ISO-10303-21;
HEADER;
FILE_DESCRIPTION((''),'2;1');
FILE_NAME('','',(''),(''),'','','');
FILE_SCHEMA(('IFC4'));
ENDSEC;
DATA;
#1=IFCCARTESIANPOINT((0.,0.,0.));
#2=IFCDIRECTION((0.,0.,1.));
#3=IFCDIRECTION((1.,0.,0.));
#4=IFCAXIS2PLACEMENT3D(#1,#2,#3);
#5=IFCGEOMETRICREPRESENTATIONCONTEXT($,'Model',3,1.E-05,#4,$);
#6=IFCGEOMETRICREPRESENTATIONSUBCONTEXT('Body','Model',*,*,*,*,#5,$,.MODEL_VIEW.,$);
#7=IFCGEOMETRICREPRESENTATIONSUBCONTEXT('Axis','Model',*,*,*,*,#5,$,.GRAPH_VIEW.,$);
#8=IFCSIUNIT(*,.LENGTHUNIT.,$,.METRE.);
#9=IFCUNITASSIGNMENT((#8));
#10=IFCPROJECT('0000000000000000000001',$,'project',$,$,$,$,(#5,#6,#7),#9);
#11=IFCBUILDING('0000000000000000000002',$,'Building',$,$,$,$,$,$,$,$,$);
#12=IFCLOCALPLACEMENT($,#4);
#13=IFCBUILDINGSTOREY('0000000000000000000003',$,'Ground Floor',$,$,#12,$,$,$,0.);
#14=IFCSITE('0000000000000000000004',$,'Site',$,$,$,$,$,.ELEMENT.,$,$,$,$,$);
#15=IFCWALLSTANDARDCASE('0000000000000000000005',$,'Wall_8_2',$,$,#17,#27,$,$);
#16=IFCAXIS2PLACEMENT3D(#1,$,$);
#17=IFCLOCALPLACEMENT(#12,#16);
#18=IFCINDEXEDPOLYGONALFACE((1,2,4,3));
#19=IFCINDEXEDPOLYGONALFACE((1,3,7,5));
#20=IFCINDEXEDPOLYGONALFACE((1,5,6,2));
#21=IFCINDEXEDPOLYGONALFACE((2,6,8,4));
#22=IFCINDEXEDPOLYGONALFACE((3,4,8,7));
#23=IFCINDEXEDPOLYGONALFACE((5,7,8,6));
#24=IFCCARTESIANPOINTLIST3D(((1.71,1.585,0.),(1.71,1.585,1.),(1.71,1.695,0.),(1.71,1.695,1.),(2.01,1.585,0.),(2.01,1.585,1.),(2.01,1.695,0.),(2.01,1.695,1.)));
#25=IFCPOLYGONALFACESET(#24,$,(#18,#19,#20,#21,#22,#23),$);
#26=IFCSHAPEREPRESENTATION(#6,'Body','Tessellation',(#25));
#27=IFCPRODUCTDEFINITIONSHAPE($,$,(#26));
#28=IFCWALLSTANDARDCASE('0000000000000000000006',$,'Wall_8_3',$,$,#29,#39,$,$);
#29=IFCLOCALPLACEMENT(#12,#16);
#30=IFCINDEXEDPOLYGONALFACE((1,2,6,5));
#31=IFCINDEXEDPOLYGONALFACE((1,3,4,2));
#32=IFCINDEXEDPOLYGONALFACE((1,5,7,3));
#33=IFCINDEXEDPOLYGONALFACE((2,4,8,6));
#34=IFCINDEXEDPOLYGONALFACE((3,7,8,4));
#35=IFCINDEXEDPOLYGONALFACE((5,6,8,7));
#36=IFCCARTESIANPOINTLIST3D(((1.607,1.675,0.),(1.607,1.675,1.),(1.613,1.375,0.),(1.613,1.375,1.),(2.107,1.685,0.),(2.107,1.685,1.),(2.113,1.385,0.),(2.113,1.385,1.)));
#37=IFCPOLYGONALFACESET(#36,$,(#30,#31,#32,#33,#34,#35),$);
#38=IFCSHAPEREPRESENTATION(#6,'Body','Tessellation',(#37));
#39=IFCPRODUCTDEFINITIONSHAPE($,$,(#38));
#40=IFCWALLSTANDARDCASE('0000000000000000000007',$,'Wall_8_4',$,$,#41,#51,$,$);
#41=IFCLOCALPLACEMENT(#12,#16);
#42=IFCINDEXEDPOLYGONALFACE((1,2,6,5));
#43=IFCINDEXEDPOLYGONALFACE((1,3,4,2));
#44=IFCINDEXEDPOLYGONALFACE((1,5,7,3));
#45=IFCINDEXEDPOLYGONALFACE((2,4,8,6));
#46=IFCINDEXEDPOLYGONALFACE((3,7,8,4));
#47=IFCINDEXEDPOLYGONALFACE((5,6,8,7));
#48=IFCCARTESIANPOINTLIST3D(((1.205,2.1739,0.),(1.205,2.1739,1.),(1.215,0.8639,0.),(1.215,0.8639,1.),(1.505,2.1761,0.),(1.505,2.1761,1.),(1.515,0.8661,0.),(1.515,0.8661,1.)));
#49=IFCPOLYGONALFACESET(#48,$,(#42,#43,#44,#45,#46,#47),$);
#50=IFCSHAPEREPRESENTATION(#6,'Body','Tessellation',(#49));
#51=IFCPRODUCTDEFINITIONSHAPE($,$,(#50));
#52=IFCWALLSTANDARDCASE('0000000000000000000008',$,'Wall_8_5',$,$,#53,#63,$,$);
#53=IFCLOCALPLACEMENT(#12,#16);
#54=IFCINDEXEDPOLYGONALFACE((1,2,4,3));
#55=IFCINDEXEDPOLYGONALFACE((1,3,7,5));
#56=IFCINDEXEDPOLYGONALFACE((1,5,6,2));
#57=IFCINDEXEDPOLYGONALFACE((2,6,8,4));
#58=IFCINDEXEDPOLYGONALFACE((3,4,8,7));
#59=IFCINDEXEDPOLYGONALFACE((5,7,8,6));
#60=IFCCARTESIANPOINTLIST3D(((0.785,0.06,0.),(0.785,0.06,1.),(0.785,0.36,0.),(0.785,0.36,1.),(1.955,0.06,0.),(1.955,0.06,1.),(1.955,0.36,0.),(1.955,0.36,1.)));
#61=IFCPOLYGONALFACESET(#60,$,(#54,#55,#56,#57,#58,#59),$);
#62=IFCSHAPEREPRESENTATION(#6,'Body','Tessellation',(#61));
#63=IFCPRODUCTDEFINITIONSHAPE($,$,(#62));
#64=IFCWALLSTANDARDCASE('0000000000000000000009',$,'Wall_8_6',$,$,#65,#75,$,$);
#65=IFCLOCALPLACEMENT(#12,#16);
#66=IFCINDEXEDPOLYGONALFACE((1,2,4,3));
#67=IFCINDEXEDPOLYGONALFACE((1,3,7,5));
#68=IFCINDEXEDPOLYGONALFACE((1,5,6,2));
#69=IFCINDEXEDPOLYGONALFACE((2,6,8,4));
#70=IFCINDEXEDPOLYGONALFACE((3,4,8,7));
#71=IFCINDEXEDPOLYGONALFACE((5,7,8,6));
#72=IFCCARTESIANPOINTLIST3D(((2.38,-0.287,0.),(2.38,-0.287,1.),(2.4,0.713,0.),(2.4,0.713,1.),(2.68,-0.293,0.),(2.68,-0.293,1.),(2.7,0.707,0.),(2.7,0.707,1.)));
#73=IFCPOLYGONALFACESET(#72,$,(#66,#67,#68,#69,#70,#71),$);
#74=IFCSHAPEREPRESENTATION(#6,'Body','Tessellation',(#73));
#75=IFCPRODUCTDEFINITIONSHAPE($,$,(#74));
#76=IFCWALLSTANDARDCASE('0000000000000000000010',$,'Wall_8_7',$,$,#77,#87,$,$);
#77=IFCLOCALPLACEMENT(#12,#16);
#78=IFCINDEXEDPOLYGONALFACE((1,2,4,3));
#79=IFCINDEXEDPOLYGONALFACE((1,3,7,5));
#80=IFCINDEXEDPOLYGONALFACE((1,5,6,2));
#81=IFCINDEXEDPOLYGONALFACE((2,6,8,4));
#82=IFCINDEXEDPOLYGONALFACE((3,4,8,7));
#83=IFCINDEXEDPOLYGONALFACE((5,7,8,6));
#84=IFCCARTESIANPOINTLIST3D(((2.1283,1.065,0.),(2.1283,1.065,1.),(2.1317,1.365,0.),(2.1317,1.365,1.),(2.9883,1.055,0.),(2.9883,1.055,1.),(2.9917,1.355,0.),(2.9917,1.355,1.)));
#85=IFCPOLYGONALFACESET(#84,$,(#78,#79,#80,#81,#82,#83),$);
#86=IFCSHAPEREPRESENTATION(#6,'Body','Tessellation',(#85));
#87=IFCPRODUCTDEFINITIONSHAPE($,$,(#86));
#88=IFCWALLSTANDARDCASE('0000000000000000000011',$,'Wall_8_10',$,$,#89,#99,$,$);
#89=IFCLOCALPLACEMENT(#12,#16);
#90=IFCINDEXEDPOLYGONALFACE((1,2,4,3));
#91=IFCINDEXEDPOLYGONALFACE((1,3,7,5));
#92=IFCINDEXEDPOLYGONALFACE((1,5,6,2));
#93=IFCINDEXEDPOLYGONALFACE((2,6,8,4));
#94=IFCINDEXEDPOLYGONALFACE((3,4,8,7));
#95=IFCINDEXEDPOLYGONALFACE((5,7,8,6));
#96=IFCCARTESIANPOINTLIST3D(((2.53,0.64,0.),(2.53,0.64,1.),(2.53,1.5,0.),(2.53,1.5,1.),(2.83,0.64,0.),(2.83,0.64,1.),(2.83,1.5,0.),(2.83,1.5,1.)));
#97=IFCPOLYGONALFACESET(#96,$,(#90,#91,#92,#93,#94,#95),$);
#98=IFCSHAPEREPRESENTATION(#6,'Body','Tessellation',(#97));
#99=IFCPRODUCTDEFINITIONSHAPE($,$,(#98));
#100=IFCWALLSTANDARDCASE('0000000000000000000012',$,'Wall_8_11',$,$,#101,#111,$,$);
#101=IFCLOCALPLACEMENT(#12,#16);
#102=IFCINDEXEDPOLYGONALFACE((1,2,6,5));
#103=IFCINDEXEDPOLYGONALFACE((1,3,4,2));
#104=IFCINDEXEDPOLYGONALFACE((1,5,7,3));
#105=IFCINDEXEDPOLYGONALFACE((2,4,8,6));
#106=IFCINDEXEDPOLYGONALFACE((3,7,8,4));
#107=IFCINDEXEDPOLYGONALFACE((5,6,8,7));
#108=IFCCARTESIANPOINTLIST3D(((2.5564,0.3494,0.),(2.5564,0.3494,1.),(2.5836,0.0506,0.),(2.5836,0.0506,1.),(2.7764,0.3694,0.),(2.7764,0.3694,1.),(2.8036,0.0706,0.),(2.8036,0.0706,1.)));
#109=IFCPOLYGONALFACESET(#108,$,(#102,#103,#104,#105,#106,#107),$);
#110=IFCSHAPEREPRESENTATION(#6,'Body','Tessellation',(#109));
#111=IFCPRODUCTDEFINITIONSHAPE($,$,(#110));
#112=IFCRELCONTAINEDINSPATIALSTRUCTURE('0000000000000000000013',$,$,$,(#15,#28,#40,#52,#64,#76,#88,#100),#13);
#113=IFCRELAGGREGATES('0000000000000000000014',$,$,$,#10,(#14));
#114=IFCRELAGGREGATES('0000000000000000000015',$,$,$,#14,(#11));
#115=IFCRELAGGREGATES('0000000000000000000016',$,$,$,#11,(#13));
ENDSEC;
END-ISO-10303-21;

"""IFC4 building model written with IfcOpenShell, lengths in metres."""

from ifc_helpers import new_model, si_unit, frame, origin_with_axes, origin_2d, place, context, subcontext, project, spatial, rectangle, extrude, element, save


model = new_model("IFC4")

# Units and contexts
model_context = context("Model", 3, precision=1e-05, world=origin_with_axes())
body_context = subcontext(model_context, "Body", "Model", "MODEL_VIEW")
axis_context = subcontext(model_context, "Axis", "Model", "GRAPH_VIEW")
ifc_project = project(units=[si_unit("LENGTHUNIT", "METRE")], contexts=[model_context, body_context, axis_context])

# Site, building, storey
site = spatial("IfcSite", under=ifc_project, Name="Site", CompositionType="ELEMENT")
building = spatial("IfcBuilding", under=site, Name="Building")
storey_placement = place(None, origin_with_axes())
storey = spatial("IfcBuildingStorey", under=building, at=storey_placement, Name="Ground Floor", Elevation=0.0)

# Walls
wall_1_placement = place(storey_placement, frame((1.86, 1.64, 0.0), z_axis=(0.0, 0.0, 1.0), x_axis=(0.0, -1.0, 0.0)))
element("IfcWallStandardCase", 1, at=wall_1_placement, inside=storey, Name="Wall_8_2", context=body_context, shape_type="SweptSolid", body=[
    extrude(rectangle(XDim=0.11, YDim=0.3, at=origin_2d()), origin_with_axes(), (0.0, 0.0, 1.0), 1.0),
])
wall_2_placement = place(storey_placement, frame((1.86, 1.53, 0.0), z_axis=(0.0, 0.0, 1.0), x_axis=(-0.9998, -0.019996, 0.0)))
element("IfcWallStandardCase", 2, at=wall_2_placement, inside=storey, Name="Wall_8_3", context=body_context, shape_type="SweptSolid", body=[
    extrude(rectangle(XDim=0.5001, YDim=0.3, at=origin_2d()), origin_with_axes(), (0.0, 0.0, 1.0), 1.0),
])
wall_3_placement = place(storey_placement, frame((1.36, 1.52, 0.0), z_axis=(0.0, 0.0, 1.0), x_axis=(0.007633, -0.999971, 0.0)))
element("IfcWallStandardCase", 3, at=wall_3_placement, inside=storey, Name="Wall_8_4", context=body_context, shape_type="SweptSolid", body=[
    extrude(rectangle(XDim=1.31, YDim=0.3, at=origin_2d()), origin_with_axes(), (0.0, 0.0, 1.0), 1.0),
])
wall_4_placement = place(storey_placement, frame((1.37, 0.21, 0.0), z_axis=(0.0, 0.0, 1.0), x_axis=(1.0, 0.0, 0.0)))
element("IfcWallStandardCase", 4, at=wall_4_placement, inside=storey, Name="Wall_8_5", context=body_context, shape_type="SweptSolid", body=[
    extrude(rectangle(XDim=1.17, YDim=0.3, at=origin_2d()), origin_with_axes(), (0.0, 0.0, 1.0), 1.0),
])
wall_5_placement = place(storey_placement, frame((2.54, 0.21, 0.0), z_axis=(0.0, 0.0, 1.0), x_axis=(0.019996, 0.9998, 0.0)))
element("IfcWallStandardCase", 5, at=wall_5_placement, inside=storey, Name="Wall_8_6", context=body_context, shape_type="SweptSolid", body=[
    extrude(rectangle(XDim=1.0002, YDim=0.3, at=origin_2d()), origin_with_axes(), (0.0, 0.0, 1.0), 1.0),
])
wall_6_placement = place(storey_placement, frame((2.56, 1.21, 0.0), z_axis=(0.0, 0.0, 1.0), x_axis=(0.999932, -0.011627, 0.0)))
element("IfcWallStandardCase", 6, at=wall_6_placement, inside=storey, Name="Wall_8_7", context=body_context, shape_type="SweptSolid", body=[
    extrude(rectangle(XDim=0.8601, YDim=0.3, at=origin_2d()), origin_with_axes(), (0.0, 0.0, 1.0), 1.0),
])
wall_7_placement = place(storey_placement, frame((2.68, 1.07, 0.0), z_axis=(0.0, 0.0, 1.0), x_axis=(0.0, -1.0, 0.0)))
element("IfcWallStandardCase", 7, at=wall_7_placement, inside=storey, Name="Wall_8_10", context=body_context, shape_type="SweptSolid", body=[
    extrude(rectangle(XDim=0.86, YDim=0.3, at=origin_2d()), origin_with_axes(), (0.0, 0.0, 1.0), 1.0),
])
wall_8_placement = place(storey_placement, frame((2.68, 0.21, 0.0), z_axis=(0.0, 0.0, 1.0), x_axis=(0.995893, 0.090536, 0.0)))
element("IfcWallStandardCase", 8, at=wall_8_placement, inside=storey, Name="Wall_8_11", context=body_context, shape_type="SweptSolid", body=[
    extrude(rectangle(XDim=0.2209, YDim=0.3, at=origin_2d()), origin_with_axes(), (0.0, 0.0, 1.0), 1.0),
])

save(model, "model.ifc")
